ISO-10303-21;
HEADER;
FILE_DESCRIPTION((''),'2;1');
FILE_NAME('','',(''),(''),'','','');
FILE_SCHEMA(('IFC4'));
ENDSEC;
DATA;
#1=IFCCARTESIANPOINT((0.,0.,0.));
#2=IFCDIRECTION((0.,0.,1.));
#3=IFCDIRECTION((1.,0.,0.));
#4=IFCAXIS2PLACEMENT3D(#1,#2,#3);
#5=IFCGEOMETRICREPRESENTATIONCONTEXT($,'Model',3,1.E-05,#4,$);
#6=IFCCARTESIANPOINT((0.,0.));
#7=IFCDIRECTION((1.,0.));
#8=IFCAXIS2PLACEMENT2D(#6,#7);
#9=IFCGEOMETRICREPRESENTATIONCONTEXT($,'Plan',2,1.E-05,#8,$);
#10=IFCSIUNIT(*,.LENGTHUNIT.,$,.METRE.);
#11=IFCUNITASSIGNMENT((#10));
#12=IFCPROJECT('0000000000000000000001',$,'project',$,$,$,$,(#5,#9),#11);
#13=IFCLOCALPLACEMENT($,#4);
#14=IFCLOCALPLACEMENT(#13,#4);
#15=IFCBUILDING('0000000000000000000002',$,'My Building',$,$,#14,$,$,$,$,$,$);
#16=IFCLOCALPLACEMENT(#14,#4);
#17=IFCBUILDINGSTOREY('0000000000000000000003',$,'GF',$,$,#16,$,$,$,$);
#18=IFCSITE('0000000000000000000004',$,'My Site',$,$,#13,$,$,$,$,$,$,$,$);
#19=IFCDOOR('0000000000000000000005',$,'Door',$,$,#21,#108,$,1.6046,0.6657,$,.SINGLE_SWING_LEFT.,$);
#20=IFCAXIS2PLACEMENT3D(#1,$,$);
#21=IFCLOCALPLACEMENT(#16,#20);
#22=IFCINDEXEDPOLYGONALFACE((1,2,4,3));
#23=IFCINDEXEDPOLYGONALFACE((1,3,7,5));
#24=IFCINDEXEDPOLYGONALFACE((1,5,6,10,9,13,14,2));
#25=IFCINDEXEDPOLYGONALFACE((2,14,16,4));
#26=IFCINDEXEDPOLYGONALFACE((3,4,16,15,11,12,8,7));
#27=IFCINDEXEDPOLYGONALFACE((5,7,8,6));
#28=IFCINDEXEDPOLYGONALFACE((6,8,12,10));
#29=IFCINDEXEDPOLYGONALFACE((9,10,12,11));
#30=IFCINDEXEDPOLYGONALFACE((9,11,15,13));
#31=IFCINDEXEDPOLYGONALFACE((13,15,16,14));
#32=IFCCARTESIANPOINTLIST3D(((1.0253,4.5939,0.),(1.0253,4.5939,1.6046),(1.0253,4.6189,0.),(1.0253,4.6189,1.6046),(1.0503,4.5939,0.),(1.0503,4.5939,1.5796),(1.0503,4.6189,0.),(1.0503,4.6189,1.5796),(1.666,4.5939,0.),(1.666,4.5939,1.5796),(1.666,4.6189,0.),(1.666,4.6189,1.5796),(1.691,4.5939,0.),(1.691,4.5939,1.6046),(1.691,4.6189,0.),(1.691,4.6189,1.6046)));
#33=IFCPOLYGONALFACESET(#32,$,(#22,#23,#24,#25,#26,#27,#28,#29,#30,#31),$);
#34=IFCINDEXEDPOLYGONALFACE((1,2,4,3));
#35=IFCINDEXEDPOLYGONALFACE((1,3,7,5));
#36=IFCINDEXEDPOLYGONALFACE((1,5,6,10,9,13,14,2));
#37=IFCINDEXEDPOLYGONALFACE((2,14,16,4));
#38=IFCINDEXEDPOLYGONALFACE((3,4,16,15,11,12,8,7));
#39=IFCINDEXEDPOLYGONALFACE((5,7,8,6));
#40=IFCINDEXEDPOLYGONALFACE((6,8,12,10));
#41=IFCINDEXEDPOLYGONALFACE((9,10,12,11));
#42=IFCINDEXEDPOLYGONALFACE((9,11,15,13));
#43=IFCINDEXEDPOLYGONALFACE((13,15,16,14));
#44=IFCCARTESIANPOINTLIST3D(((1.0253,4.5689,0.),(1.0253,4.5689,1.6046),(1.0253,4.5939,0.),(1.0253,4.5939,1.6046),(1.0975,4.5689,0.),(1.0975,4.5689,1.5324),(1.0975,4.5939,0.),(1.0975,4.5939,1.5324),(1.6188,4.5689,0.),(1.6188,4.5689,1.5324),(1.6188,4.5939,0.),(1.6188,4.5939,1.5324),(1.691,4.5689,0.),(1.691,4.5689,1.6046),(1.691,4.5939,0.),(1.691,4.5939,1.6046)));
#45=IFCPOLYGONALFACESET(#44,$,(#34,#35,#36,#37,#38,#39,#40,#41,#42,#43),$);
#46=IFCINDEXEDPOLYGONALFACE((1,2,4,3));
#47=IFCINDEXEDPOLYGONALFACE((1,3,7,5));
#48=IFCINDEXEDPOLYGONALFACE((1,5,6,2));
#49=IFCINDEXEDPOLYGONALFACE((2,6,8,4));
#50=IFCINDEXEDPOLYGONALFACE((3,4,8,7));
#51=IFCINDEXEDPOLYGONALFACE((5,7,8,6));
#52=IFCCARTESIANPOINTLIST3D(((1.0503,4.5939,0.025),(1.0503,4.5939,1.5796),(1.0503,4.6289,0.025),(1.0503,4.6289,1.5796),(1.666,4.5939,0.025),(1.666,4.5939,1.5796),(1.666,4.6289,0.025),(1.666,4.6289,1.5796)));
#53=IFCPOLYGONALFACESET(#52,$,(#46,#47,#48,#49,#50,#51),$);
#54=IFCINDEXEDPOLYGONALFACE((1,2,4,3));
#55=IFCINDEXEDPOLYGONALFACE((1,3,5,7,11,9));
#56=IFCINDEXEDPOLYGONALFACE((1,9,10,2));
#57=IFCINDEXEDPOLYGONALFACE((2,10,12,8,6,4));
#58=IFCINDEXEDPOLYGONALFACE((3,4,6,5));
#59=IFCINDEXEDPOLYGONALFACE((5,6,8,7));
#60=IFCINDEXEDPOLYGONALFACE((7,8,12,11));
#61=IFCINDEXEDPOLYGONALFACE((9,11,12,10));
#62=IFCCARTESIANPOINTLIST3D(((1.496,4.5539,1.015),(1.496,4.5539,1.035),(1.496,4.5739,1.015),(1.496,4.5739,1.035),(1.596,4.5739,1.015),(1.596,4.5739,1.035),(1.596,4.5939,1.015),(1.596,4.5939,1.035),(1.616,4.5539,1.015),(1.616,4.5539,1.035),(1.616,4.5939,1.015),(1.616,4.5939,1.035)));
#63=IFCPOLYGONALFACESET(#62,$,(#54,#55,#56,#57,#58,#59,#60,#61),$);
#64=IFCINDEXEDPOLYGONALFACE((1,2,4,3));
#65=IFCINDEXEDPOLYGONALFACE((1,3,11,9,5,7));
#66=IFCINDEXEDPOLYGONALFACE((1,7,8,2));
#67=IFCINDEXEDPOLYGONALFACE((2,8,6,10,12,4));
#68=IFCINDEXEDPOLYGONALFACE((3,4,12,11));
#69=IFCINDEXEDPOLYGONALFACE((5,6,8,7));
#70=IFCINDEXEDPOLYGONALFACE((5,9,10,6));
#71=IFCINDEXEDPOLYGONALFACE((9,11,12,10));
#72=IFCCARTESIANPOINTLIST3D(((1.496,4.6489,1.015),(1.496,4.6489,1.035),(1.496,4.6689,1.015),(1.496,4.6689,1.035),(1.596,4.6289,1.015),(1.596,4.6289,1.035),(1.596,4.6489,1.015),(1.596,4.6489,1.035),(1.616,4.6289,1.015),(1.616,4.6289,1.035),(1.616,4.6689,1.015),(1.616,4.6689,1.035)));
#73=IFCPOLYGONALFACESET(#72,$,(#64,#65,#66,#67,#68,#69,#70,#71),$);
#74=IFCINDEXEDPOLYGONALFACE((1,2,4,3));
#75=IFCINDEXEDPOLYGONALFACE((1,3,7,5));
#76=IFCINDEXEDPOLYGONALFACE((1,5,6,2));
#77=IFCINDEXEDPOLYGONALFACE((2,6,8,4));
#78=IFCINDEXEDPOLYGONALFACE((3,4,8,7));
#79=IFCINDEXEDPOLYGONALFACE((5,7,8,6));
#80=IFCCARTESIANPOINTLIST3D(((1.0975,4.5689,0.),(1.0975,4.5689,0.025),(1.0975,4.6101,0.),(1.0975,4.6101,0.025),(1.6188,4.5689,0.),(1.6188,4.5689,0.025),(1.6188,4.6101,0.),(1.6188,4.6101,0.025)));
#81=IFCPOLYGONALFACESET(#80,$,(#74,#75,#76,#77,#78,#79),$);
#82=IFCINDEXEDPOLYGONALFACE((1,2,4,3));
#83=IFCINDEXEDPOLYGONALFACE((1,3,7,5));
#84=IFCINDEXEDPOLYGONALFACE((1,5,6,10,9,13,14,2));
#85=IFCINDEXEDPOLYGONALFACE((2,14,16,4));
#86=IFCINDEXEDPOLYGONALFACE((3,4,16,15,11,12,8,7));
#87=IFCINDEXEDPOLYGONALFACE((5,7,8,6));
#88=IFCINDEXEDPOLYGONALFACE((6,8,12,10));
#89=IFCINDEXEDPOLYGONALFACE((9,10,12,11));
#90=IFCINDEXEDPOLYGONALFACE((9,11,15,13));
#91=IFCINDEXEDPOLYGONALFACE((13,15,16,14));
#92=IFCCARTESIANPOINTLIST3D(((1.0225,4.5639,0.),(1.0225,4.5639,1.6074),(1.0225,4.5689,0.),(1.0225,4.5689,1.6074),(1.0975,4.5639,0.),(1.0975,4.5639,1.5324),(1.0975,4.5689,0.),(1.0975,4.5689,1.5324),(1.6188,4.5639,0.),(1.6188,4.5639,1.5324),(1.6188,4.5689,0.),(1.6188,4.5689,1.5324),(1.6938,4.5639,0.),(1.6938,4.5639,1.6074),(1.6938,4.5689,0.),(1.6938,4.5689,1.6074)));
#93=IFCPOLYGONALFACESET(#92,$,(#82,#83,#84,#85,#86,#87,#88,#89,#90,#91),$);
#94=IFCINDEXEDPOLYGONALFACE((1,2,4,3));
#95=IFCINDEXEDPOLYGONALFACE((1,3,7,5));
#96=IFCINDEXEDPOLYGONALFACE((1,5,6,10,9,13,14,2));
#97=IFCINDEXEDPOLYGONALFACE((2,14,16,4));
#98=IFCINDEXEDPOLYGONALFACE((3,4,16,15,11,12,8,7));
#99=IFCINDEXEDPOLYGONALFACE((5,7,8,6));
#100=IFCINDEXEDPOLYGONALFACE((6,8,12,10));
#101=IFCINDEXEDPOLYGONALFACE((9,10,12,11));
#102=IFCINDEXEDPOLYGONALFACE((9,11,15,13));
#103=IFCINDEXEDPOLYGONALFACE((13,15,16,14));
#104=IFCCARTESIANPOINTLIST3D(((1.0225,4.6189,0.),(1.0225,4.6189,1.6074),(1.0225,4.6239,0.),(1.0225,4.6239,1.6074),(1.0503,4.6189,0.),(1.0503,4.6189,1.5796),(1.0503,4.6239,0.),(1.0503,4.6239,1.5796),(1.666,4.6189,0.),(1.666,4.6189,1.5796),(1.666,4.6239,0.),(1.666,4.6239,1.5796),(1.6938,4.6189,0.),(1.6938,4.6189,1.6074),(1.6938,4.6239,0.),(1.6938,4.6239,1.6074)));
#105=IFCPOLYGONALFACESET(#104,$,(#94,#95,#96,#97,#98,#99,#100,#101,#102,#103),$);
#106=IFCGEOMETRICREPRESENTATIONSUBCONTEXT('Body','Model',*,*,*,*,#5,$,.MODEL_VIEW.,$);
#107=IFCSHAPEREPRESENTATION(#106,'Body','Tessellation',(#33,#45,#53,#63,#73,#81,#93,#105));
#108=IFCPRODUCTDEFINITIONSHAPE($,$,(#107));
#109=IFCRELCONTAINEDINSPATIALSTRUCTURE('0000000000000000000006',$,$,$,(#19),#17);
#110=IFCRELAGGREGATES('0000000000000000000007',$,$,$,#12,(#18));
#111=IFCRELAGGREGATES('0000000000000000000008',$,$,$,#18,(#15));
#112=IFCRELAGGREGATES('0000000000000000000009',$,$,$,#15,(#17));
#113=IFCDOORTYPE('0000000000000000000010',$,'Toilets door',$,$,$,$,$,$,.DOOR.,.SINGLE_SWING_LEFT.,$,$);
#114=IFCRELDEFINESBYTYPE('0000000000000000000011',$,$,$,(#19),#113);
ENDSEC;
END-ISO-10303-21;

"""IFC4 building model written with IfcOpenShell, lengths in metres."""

from ifc_helpers import new_model, entity, si_unit, frame, origin_with_axes, origin_2d_with_axis, place, context, subcontext, project, spatial, line, indexed_curve, outline, extrude, shape, source, transform, mapped, type_object, type_shapes, element, save


model = new_model("IFC4")

# Units and contexts
model_context = context("Model", 3, precision=1e-05, world=origin_with_axes())
plan_context = context("Plan", 2, precision=1e-05, world=origin_2d_with_axis())
body_context_1 = subcontext(model_context, "Body", "Model", "MODEL_VIEW")
body_context_2 = subcontext(plan_context, "Body", "Plan", "PLAN_VIEW")
ifc_project = project(units=[si_unit("LENGTHUNIT", "METRE")], contexts=[model_context, plan_context])

# Site, building, storey
site_placement = place(None, origin_with_axes())
site = spatial("IfcSite", under=ifc_project, at=site_placement, Name="My Site")
building_placement = place(site_placement, origin_with_axes())
building = spatial("IfcBuilding", under=site, at=building_placement, Name="My Building")
storey_placement = place(building_placement, origin_with_axes())
storey = spatial("IfcBuildingStorey", under=building, at=storey_placement, Name="GF")

# Shared definitions
door_type_1 = type_object("IfcDoorType", Name="Toilets door", OperationType="SINGLE_SWING_LEFT", PredefinedType="DOOR")
shared_shape_1 = source(origin_with_axes(), body_context_1, "Body", "SweptSolid", [
    extrude(outline(indexed_curve([(0.0, 0.0), (0.0, 1.6046), (0.6657, 1.6046), (0.6657, 0.0), (0.6407, 0.0), (0.6407, 1.5796), (0.025, 1.5796), (0.025, 0.0)], segments=[line(1, 2, 3, 4, 5, 6, 7, 8, 1)])), frame((0.0, 0.025, 0.0), z_axis=(0.0, -1.0, 0.0), x_axis=(1.0, 0.0, 0.0)), (0.0, 0.0, -1.0), 0.025),
    extrude(outline(indexed_curve([(0.0, 0.0), (0.0, 1.6046), (0.6657, 1.6046), (0.6657, 0.0), (0.5935, 0.0), (0.5935, 1.5324), (0.0722, 1.5324), (0.0722, 0.0)], segments=[line(1, 2, 3, 4, 5, 6, 7, 8, 1)])), frame((0.0, 0.0, 0.0), z_axis=(0.0, -1.0, 0.0), x_axis=(1.0, 0.0, 0.0)), (0.0, 0.0, -1.0), 0.025),
    extrude(outline(indexed_curve([(0.0, 0.0), (0.6157, 0.0), (0.6157, 0.035), (0.0, 0.035)], segments=[line(1, 2, 3, 4, 1)])), frame((0.025, 0.025, 0.025), z_axis=(0.0, 0.0, 1.0), x_axis=(1.0, 0.0, 0.0)), (0.0, 0.0, 1.0), 1.5546),
    extrude(outline(indexed_curve([(0.0, 0.0), (0.0, -0.04), (-0.12, -0.04), (-0.12, -0.02), (-0.02, -0.02), (-0.02, 0.0)], segments=[line(1, 2, 3, 4, 5, 6, 1)])), frame((0.5907, 0.025, 1.015), z_axis=(0.0, 0.0, 1.0), x_axis=(1.0, 0.0, 0.0)), (0.0, 0.0, 1.0), 0.02),
    extrude(outline(indexed_curve([(0.0, 0.0), (0.0, 0.04), (-0.12, 0.04), (-0.12, 0.02), (-0.02, 0.02), (-0.02, 0.0)], segments=[line(1, 2, 3, 4, 5, 6, 1)])), frame((0.5907, 0.06, 1.015), z_axis=(0.0, 0.0, 1.0), x_axis=(1.0, 0.0, 0.0)), (0.0, 0.0, 1.0), 0.02),
    extrude(outline(indexed_curve([(0.0, 0.0), (0.5214, 0.0), (0.5214, 0.0412), (0.0, 0.0412)], segments=[line(1, 2, 3, 4, 1)])), frame((0.0722, 0.0, 0.0), z_axis=(0.0, 0.0, 1.0), x_axis=(1.0, 0.0, 0.0)), (0.0, 0.0, 1.0), 0.025),
    extrude(outline(indexed_curve([(0.0, 0.0), (0.0, 1.6074), (0.6714, 1.6074), (0.6714, 0.0), (0.5964, 0.0), (0.5964, 1.5324), (0.075, 1.5324), (0.075, 0.0)], segments=[line(1, 2, 3, 4, 5, 6, 7, 8, 1)])), frame((-0.0028, -0.005, 0.0), z_axis=(0.0, -1.0, 0.0), x_axis=(1.0, 0.0, 0.0)), (0.0, 0.0, -1.0), 0.005),
    extrude(outline(indexed_curve([(0.0, 0.0), (0.0, 1.6074), (0.6714, 1.6074), (0.6714, 0.0), (0.6435, 0.0), (0.6435, 1.5796), (0.0278, 1.5796), (0.0278, 0.0)], segments=[line(1, 2, 3, 4, 5, 6, 7, 8, 1)])), frame((-0.0028, 0.05, 0.0), z_axis=(0.0, -1.0, 0.0), x_axis=(1.0, 0.0, 0.0)), (0.0, 0.0, -1.0), 0.005),
])
shared_shape_2 = source(origin_with_axes(), body_context_2, "Body", "Curve2D", [
    entity("IfcIndexedPolyCurve", entity("IfcCartesianPointList2D", [[0.0, 0.0], [0.0, 0.05], [0.025, 0.05], [0.025, 0.025], [0.0722, 0.025], [0.0722, 0.0]]), [entity("IfcLineIndex", [1, 2, 3, 4, 5, 6, 1])]),
    entity("IfcIndexedPolyCurve", entity("IfcCartesianPointList2D", [[0.6657, 0.0], [0.6657, 0.05], [0.6407, 0.05], [0.6407, 0.025], [0.5935, 0.025], [0.5935, 0.0]]), [entity("IfcLineIndex", [1, 2, 3, 4, 5, 6, 1])]),
    entity("IfcTrimmedCurve", entity("IfcEllipse", entity("IfcAxis2Placement2D", entity("IfcCartesianPoint", [0.06, 0.05]), entity("IfcDirection", [1.0, 0.0])), 0.5807, 0.6157), [entity("IfcCartesianPoint", [0.6407, 0.05])], [entity("IfcCartesianPoint", [0.06, 0.6657])], True, "CARTESIAN"),
    entity("IfcIndexedPolyCurve", entity("IfcCartesianPointList2D", [[0.025, 0.05], [0.06, 0.05], [0.06, 0.6657], [0.025, 0.6657]]), [entity("IfcLineIndex", [1, 2, 3, 4, 1])]),
])
type_shapes(door_type_1, [shared_shape_1, shared_shape_2])

# Door
door_1_placement = place(storey_placement, frame((1.0253, 4.5689, 0.0), z_axis=(0.0, 0.0, 1.0), x_axis=(1.0, 0.0, 0.0)))
element("IfcDoor", 1, at=door_1_placement, inside=storey, type_object=door_type_1, Name="Door", OperationType="SINGLE_SWING_LEFT", OverallHeight=1.6046, OverallWidth=0.6657, shapes=[
    shape(body_context_1, "Body", "MappedRepresentation", [mapped(shared_shape_1, transform((0.0, 0.0, 0.0), x_axis=(1.0, 0.0, 0.0), y_axis=(0.0, 1.0, 0.0), z_axis=(0.0, 0.0, 1.0), scale=1.0))]),
    shape(body_context_2, "Body", "MappedRepresentation", [mapped(shared_shape_2, transform((0.0, 0.0, 0.0), x_axis=(1.0, 0.0, 0.0), y_axis=(0.0, 1.0, 0.0), z_axis=(0.0, 0.0, 1.0), scale=1.0))]),
])

save(model, "model.ifc")
